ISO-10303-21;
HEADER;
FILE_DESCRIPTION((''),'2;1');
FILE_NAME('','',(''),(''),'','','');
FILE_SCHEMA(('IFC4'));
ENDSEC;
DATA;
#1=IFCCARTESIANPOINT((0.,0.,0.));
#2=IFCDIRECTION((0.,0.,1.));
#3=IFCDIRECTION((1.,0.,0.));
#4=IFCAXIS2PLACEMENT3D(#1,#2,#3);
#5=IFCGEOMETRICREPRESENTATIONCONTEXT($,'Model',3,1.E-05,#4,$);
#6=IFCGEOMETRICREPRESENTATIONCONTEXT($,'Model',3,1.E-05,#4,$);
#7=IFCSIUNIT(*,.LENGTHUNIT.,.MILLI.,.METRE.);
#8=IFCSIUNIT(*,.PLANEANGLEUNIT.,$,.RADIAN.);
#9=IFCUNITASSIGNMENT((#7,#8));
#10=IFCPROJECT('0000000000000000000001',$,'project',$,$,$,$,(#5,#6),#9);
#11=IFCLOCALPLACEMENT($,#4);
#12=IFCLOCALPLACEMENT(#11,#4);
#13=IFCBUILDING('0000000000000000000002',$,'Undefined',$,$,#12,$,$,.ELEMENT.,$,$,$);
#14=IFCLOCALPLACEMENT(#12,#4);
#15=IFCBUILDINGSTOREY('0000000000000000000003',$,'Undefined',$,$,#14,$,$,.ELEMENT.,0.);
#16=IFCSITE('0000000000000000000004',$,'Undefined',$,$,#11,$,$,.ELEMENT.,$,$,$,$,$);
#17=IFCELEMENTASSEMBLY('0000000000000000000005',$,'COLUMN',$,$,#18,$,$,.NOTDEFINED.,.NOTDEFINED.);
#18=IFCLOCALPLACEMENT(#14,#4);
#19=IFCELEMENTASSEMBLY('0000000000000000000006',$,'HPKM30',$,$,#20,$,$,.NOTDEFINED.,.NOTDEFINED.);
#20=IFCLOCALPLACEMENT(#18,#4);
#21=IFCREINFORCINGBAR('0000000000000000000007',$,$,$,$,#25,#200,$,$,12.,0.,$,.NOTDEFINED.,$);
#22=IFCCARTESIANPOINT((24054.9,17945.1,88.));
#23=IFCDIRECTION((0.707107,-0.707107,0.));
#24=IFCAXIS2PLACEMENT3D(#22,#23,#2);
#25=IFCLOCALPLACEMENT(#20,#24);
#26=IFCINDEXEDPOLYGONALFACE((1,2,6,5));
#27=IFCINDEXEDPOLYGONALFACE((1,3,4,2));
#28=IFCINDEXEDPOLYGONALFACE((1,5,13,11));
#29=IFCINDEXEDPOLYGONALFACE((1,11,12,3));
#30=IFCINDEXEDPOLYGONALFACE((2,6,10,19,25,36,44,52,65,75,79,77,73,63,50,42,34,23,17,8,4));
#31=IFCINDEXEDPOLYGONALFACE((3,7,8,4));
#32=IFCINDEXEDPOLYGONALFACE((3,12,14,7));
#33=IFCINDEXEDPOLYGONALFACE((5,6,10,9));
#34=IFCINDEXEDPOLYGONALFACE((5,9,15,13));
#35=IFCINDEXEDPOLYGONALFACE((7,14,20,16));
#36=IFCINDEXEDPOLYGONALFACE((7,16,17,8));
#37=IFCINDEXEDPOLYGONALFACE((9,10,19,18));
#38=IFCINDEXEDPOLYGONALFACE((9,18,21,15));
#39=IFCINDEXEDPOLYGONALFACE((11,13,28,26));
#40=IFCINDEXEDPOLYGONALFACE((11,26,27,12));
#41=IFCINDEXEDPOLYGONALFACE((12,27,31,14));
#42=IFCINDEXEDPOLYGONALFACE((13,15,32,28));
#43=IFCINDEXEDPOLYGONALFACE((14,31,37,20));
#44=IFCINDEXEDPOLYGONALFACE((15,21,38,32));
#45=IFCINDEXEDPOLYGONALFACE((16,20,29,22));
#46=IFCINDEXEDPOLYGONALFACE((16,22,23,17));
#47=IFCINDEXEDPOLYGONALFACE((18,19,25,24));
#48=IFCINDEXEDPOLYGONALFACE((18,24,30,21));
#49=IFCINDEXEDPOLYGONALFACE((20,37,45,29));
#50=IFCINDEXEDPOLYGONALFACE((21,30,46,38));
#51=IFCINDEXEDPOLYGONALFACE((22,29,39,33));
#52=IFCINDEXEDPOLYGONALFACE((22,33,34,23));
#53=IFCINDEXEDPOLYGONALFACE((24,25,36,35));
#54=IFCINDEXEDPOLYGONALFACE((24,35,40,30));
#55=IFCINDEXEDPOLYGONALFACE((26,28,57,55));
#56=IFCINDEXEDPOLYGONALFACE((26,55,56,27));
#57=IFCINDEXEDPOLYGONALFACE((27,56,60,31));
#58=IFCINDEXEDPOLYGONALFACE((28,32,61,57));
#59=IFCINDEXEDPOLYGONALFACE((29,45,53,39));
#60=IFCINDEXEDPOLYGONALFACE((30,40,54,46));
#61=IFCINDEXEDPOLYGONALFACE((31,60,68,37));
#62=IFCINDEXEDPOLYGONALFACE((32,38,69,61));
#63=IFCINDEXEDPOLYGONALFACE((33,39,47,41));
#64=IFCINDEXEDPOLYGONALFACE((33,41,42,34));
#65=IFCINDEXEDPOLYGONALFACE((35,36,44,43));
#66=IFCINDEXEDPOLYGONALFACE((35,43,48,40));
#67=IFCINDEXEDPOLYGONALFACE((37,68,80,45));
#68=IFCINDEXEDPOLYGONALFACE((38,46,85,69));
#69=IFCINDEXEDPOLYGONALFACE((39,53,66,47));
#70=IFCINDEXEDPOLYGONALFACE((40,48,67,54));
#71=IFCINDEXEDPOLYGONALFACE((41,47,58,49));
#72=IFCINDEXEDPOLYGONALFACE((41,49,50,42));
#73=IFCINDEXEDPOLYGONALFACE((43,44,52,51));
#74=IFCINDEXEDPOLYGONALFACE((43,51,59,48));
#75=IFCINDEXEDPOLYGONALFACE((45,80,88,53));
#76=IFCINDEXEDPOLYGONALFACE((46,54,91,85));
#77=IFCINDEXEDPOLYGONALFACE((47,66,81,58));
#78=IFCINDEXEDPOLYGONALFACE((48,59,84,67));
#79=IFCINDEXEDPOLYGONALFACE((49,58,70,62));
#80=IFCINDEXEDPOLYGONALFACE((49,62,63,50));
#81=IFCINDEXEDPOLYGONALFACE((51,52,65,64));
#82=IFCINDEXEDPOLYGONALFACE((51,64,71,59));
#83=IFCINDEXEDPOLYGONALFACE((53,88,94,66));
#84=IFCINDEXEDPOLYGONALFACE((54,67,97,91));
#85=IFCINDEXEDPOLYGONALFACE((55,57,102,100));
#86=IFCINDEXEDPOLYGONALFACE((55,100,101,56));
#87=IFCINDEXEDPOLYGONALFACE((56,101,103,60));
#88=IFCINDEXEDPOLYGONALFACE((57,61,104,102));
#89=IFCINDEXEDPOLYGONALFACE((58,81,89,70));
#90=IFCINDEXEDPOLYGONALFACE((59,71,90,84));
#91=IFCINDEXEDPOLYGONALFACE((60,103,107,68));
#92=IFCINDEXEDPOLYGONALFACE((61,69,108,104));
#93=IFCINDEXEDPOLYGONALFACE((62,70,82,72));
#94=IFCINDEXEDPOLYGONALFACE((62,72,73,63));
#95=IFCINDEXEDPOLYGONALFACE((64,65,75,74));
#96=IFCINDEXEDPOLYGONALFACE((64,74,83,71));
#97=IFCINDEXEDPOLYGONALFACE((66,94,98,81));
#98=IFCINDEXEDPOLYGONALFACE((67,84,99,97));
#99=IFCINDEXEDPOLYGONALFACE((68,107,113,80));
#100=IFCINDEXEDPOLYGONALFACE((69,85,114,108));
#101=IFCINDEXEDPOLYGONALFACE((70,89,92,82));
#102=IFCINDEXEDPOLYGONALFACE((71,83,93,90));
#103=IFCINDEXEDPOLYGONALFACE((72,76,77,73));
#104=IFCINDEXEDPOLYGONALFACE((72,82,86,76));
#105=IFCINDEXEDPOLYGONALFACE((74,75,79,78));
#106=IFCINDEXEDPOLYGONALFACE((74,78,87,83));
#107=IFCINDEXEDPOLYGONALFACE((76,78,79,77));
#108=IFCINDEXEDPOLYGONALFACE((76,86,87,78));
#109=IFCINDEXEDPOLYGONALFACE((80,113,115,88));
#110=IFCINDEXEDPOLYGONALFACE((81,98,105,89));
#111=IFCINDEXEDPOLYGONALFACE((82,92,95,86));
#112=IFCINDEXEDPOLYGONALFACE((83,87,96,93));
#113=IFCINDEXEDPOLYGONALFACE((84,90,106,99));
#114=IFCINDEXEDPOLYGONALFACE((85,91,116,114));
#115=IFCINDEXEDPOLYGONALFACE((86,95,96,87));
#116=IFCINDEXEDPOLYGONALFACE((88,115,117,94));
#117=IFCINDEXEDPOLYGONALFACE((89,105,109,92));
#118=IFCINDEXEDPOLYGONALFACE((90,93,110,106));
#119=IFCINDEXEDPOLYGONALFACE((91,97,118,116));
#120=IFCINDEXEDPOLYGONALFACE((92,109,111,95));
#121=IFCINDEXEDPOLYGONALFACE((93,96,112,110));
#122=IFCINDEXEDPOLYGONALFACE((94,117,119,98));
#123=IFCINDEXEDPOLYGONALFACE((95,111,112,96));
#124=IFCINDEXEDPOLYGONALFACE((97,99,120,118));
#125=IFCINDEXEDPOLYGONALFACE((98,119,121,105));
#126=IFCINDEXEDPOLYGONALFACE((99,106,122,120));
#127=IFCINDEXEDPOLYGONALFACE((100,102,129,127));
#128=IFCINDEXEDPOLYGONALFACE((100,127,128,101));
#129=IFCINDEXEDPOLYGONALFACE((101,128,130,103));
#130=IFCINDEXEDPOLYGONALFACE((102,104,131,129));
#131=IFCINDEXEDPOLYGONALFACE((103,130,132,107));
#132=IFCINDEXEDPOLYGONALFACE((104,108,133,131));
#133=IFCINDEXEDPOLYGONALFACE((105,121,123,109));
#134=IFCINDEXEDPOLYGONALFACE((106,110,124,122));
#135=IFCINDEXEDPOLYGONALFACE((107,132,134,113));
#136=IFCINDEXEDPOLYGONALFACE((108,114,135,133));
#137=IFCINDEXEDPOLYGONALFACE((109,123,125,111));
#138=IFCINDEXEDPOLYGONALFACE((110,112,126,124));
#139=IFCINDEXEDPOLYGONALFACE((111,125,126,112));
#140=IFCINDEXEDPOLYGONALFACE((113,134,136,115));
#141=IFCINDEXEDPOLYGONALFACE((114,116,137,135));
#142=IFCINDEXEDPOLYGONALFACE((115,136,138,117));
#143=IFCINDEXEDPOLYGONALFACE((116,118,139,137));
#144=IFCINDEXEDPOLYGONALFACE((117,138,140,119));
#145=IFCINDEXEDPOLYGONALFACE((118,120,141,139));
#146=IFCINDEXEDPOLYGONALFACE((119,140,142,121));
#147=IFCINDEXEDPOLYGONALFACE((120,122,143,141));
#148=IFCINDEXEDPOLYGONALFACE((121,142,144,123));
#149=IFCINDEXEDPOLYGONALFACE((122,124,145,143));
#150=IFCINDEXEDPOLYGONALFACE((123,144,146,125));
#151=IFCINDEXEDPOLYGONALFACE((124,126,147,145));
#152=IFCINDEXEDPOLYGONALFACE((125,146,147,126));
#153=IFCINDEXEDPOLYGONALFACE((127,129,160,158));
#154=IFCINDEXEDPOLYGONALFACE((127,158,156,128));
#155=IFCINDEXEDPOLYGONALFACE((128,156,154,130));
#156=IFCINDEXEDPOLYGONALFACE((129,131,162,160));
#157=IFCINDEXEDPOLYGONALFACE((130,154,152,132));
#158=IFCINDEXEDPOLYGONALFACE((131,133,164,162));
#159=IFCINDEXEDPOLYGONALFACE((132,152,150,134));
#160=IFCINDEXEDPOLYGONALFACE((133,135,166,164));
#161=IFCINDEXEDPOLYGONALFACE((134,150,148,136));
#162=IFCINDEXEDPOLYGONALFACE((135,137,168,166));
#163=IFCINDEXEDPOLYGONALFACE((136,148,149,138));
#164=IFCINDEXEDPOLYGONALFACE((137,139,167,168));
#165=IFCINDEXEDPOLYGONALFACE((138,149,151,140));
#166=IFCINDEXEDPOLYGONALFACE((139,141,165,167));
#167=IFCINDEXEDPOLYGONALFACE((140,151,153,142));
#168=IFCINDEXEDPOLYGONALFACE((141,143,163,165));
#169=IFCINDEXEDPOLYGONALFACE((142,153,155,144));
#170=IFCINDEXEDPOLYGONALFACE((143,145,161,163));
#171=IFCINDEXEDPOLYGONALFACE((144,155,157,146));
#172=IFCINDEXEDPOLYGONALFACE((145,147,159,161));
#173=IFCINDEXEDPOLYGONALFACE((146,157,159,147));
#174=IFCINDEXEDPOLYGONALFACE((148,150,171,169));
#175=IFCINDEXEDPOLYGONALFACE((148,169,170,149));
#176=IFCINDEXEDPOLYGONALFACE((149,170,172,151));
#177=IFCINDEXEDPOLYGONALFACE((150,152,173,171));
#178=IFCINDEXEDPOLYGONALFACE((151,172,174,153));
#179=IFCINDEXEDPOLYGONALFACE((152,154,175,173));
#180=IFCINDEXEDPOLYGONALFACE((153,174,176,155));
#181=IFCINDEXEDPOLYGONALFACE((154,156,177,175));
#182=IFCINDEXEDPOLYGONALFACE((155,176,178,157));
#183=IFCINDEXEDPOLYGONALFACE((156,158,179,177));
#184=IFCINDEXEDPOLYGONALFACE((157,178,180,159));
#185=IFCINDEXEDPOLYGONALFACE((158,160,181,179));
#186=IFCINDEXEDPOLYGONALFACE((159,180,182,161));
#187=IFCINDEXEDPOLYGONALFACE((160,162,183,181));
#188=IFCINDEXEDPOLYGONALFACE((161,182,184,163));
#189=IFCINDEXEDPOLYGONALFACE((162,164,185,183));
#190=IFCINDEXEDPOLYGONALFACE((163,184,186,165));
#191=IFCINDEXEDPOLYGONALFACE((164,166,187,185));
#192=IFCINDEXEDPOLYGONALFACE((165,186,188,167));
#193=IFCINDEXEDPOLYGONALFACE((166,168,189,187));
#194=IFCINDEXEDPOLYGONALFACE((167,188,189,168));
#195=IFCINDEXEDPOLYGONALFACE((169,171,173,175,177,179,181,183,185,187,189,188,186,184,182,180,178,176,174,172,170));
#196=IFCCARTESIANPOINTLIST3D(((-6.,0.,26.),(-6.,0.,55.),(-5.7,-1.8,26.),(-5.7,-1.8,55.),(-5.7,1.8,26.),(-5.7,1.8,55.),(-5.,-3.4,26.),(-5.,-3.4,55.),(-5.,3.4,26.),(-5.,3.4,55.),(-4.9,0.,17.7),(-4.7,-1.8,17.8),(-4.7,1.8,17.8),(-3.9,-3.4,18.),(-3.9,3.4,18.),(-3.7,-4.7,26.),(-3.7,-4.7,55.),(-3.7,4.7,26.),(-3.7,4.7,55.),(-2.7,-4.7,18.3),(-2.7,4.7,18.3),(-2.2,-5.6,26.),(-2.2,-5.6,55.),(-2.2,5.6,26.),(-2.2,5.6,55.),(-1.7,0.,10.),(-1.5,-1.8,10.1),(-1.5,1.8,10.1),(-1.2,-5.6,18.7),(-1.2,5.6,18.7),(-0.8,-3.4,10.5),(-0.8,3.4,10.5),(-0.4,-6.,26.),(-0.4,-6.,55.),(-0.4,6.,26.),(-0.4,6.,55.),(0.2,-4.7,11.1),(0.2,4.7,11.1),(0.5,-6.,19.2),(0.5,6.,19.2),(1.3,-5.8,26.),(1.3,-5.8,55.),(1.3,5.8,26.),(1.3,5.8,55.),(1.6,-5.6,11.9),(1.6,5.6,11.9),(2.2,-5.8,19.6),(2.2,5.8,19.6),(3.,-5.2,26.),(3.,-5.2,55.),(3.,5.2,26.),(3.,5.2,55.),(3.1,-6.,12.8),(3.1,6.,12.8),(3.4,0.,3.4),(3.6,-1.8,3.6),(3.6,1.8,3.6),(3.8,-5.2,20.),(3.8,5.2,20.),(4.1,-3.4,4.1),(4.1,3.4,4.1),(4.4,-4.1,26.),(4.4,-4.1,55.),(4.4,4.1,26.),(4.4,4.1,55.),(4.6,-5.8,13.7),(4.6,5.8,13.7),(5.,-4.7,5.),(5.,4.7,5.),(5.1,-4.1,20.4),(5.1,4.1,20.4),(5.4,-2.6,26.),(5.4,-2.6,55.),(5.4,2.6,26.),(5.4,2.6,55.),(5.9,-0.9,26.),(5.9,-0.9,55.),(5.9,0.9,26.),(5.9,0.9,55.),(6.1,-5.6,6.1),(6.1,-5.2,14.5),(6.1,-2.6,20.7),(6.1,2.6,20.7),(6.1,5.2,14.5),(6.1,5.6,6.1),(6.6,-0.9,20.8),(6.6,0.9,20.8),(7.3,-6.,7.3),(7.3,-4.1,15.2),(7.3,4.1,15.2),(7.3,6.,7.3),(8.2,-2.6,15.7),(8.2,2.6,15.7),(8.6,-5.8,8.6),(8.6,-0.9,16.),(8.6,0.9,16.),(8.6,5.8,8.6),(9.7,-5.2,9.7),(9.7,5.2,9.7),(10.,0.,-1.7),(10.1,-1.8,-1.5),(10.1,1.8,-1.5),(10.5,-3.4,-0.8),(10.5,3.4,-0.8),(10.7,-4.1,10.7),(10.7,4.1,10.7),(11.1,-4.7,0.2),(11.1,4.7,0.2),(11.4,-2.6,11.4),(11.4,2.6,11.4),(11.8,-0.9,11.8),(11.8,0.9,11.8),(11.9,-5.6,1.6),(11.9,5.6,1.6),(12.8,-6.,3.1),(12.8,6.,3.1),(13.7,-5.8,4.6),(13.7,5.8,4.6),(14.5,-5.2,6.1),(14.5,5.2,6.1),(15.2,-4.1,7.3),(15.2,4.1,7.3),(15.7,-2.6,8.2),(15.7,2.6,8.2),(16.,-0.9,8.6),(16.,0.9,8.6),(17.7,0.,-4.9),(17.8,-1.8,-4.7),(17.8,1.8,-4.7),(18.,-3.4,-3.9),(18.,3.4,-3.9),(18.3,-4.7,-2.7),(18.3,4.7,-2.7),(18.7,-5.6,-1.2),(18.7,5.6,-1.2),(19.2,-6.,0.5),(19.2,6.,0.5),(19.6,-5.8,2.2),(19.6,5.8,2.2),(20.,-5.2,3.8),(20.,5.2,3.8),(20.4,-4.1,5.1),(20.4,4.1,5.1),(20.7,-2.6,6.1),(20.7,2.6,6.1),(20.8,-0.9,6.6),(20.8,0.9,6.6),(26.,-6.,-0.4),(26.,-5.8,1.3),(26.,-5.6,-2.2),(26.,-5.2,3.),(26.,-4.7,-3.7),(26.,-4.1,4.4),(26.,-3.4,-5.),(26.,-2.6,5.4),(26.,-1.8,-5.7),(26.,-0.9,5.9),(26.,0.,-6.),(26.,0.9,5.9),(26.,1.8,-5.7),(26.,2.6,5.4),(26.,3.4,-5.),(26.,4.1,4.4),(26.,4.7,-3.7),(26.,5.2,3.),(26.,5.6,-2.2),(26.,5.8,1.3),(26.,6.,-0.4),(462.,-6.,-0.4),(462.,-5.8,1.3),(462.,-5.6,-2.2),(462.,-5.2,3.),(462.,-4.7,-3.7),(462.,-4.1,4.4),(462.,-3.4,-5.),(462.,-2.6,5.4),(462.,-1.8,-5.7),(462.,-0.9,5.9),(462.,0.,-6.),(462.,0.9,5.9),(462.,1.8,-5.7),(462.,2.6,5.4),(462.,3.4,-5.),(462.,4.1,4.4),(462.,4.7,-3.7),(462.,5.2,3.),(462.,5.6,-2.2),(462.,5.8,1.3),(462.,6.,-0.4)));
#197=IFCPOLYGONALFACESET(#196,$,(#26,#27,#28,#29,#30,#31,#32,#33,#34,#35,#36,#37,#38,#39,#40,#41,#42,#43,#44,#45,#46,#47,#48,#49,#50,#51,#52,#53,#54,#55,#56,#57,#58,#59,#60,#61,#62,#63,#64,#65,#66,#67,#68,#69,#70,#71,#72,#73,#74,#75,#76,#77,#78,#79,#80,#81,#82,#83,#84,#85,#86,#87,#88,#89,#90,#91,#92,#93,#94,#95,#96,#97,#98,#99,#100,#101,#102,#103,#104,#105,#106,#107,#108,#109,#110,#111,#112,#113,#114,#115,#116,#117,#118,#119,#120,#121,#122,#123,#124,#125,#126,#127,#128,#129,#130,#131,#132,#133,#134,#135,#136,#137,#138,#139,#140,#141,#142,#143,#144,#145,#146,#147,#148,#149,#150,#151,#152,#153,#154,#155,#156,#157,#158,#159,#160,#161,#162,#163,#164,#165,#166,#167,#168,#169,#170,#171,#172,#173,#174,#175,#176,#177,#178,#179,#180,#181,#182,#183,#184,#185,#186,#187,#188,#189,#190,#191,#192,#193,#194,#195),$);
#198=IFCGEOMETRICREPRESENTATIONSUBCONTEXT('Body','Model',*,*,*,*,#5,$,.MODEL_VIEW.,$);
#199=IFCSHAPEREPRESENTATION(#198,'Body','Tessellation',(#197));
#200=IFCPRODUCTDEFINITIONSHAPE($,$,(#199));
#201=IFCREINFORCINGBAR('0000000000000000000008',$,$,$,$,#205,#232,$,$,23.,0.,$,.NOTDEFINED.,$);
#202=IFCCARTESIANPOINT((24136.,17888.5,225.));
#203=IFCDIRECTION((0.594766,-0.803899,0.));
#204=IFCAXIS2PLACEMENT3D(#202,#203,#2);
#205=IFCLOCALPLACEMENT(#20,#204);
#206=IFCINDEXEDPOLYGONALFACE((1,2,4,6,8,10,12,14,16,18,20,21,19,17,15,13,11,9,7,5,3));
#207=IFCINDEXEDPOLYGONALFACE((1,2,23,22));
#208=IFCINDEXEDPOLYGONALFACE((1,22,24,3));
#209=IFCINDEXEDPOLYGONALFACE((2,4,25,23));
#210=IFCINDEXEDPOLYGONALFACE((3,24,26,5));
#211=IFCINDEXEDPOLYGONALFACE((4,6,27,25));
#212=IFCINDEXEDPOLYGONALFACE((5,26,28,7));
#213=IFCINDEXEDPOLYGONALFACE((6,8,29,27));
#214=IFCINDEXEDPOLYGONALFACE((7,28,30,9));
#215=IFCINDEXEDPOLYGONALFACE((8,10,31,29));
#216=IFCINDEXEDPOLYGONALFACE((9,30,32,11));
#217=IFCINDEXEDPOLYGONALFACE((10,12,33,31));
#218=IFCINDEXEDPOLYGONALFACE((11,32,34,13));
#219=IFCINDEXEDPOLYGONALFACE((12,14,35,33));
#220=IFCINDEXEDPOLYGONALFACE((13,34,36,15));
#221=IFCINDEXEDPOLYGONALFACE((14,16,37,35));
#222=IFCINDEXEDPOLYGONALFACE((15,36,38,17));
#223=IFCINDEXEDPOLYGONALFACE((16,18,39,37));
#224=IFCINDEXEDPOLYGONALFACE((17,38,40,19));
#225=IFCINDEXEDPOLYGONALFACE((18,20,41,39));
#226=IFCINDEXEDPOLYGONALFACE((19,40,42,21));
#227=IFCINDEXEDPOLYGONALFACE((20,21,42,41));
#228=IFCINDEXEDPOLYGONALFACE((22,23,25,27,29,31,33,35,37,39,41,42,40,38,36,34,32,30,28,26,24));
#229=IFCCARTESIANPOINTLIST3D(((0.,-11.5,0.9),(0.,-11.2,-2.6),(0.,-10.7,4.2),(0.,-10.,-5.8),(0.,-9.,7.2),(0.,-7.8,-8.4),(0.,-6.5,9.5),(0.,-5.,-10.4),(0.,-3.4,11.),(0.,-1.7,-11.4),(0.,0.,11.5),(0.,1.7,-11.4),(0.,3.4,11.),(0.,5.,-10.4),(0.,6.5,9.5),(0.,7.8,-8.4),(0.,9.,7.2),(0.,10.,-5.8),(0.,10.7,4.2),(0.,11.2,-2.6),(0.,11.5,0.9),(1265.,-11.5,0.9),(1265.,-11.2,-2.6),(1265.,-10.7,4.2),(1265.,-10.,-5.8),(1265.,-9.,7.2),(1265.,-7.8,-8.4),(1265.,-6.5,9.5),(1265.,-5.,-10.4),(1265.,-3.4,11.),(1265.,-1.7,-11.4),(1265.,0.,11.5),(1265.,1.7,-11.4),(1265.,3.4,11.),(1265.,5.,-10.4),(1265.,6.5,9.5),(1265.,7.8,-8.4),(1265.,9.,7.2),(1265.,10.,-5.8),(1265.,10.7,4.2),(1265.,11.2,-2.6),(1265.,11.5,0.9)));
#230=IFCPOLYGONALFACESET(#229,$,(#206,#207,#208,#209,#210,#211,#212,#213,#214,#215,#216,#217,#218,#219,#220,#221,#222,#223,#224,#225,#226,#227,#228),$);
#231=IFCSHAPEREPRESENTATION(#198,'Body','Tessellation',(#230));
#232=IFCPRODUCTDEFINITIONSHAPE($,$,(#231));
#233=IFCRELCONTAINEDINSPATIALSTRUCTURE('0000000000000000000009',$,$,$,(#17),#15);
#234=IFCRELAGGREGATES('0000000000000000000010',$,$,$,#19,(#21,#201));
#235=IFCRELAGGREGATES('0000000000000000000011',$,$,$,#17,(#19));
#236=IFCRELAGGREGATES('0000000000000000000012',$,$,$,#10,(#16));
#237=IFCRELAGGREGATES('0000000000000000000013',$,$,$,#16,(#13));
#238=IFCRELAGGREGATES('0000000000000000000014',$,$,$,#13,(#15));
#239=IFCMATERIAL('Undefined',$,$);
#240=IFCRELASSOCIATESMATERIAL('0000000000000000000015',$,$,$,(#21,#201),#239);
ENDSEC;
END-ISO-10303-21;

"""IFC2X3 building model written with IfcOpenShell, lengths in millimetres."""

from ifc_helpers import new_model, entity, si_unit, frame, origin_with_axes, place, context, subcontext, project, spatial, source, transform, mapped, material, element, aggregate, save


model = new_model("IFC2X3")

# Units and contexts
model_context_1 = context("Model", 3, precision=1e-05, world=origin_with_axes())
model_context_2 = context("Model", 3, precision=1e-05, world=origin_with_axes())
body_context = subcontext(model_context_1, "Body", "Model", "MODEL_VIEW")
ifc_project = project(units=[si_unit("LENGTHUNIT", "METRE", prefix="MILLI"), si_unit("PLANEANGLEUNIT", "RADIAN")], contexts=[model_context_1, model_context_2])

# Site, building, storey
site_placement = place(None, origin_with_axes())
site = spatial("IfcSite", under=ifc_project, at=site_placement, Name="Undefined", CompositionType="ELEMENT")
building_placement = place(site_placement, origin_with_axes())
building = spatial("IfcBuilding", under=site, at=building_placement, Name="Undefined", CompositionType="ELEMENT")
storey_placement = place(building_placement, origin_with_axes())
storey = spatial("IfcBuildingStorey", under=building, at=storey_placement, Name="Undefined", CompositionType="ELEMENT", Elevation=0.0)

# Element assemblies
assembly_1_placement = place(storey_placement, origin_with_axes())
assembly_1 = element("IfcElementAssembly", 1, at=assembly_1_placement, inside=storey, Name="COLUMN", AssemblyPlace="NOTDEFINED", PredefinedType="NOTDEFINED")
assembly_2_placement = place(assembly_1_placement, origin_with_axes())
assembly_2 = element("IfcElementAssembly", 2, at=assembly_2_placement, Name="HPKM30", AssemblyPlace="NOTDEFINED", PredefinedType="NOTDEFINED")
ifc_material_1 = material(Name="Undefined")

# Reinforcing bars
shared_shape_1 = source(origin_with_axes(), body_context, "Body", "AdvancedSweptSolid", [
    entity("IfcSweptDiskSolid", entity("IfcCompositeCurve", [entity("IfcCompositeCurveSegment", "CONTINUOUS", True, entity("IfcTrimmedCurve", entity("IfcLine", entity("IfcCartesianPoint", [0.0, 0.0, 0.0]), entity("IfcVector", entity("IfcDirection", [0.0, 0.0, -1.0]), 1.0)), [entity("IfcParameterValue", 0.0)], [entity("IfcParameterValue", 29.0)], True, "PARAMETER")), entity("IfcCompositeCurveSegment", "CONTINUOUS", True, entity("IfcTrimmedCurve", entity("IfcCircle", entity("IfcAxis2Placement3D", entity("IfcCartesianPoint", [26.0, 0.0, -29.0]), entity("IfcDirection", [0.0, -1.0, 0.0]), entity("IfcDirection", [-1.0, 0.0, 0.0])), 26.0), [entity("IfcParameterValue", 0.0)], [entity("IfcParameterValue", 1.570796)], True, "PARAMETER")), entity("IfcCompositeCurveSegment", "DISCONTINUOUS", True, entity("IfcTrimmedCurve", entity("IfcLine", entity("IfcCartesianPoint", [26.0, 0.0, -55.0]), entity("IfcVector", entity("IfcDirection", [1.0, 0.0, 0.0]), 1.0)), [entity("IfcParameterValue", 0.0)], [entity("IfcParameterValue", 436.0)], True, "PARAMETER"))], False), 6.0, None, 0.0, 466.6),
])
reinforcing_bar_1_placement = place(assembly_2_placement, frame((24054.9, 17945.1, 88.0), z_axis=(0.707107, -0.707107, 0.0), x_axis=(0.0, 0.0, 1.0)))
reinforcing_bar_1 = element("IfcReinforcingBar", 3, at=reinforcing_bar_1_placement, material=ifc_material_1, BarRole="NOTDEFINED", CrossSectionArea=0.0, NominalDiameter=12.0, context=body_context, shape_type="MappedRepresentation", body=[
    mapped(shared_shape_1, transform((0.0, 0.0, 55.0))),
])
shared_shape_2 = source(origin_with_axes(), body_context, "Body", "AdvancedSweptSolid", [
    entity("IfcSweptDiskSolid", entity("IfcTrimmedCurve", entity("IfcLine", entity("IfcCartesianPoint", [0.0, 0.0, 0.0]), entity("IfcVector", entity("IfcDirection", [1.0, 0.0, 0.0]), 1.0)), [entity("IfcParameterValue", 0.0)], [entity("IfcParameterValue", 1265.0)], True, "PARAMETER"), 11.5, None, 0.0, 1265.0),
])
reinforcing_bar_2_placement = place(assembly_2_placement, frame((24136.0, 17888.5, 225.0), z_axis=(0.594766, -0.803899, 0.0), x_axis=(0.0, 0.0, 1.0)))
reinforcing_bar_2 = element("IfcReinforcingBar", 4, at=reinforcing_bar_2_placement, material=ifc_material_1, BarRole="NOTDEFINED", CrossSectionArea=0.0, NominalDiameter=23.0, context=body_context, shape_type="MappedRepresentation", body=[
    mapped(shared_shape_2, transform((0.0, 0.0, 0.0))),
])
aggregate(assembly_2, [reinforcing_bar_1, reinforcing_bar_2])
aggregate(assembly_1, [assembly_2])

save(model, "model.ifc")
